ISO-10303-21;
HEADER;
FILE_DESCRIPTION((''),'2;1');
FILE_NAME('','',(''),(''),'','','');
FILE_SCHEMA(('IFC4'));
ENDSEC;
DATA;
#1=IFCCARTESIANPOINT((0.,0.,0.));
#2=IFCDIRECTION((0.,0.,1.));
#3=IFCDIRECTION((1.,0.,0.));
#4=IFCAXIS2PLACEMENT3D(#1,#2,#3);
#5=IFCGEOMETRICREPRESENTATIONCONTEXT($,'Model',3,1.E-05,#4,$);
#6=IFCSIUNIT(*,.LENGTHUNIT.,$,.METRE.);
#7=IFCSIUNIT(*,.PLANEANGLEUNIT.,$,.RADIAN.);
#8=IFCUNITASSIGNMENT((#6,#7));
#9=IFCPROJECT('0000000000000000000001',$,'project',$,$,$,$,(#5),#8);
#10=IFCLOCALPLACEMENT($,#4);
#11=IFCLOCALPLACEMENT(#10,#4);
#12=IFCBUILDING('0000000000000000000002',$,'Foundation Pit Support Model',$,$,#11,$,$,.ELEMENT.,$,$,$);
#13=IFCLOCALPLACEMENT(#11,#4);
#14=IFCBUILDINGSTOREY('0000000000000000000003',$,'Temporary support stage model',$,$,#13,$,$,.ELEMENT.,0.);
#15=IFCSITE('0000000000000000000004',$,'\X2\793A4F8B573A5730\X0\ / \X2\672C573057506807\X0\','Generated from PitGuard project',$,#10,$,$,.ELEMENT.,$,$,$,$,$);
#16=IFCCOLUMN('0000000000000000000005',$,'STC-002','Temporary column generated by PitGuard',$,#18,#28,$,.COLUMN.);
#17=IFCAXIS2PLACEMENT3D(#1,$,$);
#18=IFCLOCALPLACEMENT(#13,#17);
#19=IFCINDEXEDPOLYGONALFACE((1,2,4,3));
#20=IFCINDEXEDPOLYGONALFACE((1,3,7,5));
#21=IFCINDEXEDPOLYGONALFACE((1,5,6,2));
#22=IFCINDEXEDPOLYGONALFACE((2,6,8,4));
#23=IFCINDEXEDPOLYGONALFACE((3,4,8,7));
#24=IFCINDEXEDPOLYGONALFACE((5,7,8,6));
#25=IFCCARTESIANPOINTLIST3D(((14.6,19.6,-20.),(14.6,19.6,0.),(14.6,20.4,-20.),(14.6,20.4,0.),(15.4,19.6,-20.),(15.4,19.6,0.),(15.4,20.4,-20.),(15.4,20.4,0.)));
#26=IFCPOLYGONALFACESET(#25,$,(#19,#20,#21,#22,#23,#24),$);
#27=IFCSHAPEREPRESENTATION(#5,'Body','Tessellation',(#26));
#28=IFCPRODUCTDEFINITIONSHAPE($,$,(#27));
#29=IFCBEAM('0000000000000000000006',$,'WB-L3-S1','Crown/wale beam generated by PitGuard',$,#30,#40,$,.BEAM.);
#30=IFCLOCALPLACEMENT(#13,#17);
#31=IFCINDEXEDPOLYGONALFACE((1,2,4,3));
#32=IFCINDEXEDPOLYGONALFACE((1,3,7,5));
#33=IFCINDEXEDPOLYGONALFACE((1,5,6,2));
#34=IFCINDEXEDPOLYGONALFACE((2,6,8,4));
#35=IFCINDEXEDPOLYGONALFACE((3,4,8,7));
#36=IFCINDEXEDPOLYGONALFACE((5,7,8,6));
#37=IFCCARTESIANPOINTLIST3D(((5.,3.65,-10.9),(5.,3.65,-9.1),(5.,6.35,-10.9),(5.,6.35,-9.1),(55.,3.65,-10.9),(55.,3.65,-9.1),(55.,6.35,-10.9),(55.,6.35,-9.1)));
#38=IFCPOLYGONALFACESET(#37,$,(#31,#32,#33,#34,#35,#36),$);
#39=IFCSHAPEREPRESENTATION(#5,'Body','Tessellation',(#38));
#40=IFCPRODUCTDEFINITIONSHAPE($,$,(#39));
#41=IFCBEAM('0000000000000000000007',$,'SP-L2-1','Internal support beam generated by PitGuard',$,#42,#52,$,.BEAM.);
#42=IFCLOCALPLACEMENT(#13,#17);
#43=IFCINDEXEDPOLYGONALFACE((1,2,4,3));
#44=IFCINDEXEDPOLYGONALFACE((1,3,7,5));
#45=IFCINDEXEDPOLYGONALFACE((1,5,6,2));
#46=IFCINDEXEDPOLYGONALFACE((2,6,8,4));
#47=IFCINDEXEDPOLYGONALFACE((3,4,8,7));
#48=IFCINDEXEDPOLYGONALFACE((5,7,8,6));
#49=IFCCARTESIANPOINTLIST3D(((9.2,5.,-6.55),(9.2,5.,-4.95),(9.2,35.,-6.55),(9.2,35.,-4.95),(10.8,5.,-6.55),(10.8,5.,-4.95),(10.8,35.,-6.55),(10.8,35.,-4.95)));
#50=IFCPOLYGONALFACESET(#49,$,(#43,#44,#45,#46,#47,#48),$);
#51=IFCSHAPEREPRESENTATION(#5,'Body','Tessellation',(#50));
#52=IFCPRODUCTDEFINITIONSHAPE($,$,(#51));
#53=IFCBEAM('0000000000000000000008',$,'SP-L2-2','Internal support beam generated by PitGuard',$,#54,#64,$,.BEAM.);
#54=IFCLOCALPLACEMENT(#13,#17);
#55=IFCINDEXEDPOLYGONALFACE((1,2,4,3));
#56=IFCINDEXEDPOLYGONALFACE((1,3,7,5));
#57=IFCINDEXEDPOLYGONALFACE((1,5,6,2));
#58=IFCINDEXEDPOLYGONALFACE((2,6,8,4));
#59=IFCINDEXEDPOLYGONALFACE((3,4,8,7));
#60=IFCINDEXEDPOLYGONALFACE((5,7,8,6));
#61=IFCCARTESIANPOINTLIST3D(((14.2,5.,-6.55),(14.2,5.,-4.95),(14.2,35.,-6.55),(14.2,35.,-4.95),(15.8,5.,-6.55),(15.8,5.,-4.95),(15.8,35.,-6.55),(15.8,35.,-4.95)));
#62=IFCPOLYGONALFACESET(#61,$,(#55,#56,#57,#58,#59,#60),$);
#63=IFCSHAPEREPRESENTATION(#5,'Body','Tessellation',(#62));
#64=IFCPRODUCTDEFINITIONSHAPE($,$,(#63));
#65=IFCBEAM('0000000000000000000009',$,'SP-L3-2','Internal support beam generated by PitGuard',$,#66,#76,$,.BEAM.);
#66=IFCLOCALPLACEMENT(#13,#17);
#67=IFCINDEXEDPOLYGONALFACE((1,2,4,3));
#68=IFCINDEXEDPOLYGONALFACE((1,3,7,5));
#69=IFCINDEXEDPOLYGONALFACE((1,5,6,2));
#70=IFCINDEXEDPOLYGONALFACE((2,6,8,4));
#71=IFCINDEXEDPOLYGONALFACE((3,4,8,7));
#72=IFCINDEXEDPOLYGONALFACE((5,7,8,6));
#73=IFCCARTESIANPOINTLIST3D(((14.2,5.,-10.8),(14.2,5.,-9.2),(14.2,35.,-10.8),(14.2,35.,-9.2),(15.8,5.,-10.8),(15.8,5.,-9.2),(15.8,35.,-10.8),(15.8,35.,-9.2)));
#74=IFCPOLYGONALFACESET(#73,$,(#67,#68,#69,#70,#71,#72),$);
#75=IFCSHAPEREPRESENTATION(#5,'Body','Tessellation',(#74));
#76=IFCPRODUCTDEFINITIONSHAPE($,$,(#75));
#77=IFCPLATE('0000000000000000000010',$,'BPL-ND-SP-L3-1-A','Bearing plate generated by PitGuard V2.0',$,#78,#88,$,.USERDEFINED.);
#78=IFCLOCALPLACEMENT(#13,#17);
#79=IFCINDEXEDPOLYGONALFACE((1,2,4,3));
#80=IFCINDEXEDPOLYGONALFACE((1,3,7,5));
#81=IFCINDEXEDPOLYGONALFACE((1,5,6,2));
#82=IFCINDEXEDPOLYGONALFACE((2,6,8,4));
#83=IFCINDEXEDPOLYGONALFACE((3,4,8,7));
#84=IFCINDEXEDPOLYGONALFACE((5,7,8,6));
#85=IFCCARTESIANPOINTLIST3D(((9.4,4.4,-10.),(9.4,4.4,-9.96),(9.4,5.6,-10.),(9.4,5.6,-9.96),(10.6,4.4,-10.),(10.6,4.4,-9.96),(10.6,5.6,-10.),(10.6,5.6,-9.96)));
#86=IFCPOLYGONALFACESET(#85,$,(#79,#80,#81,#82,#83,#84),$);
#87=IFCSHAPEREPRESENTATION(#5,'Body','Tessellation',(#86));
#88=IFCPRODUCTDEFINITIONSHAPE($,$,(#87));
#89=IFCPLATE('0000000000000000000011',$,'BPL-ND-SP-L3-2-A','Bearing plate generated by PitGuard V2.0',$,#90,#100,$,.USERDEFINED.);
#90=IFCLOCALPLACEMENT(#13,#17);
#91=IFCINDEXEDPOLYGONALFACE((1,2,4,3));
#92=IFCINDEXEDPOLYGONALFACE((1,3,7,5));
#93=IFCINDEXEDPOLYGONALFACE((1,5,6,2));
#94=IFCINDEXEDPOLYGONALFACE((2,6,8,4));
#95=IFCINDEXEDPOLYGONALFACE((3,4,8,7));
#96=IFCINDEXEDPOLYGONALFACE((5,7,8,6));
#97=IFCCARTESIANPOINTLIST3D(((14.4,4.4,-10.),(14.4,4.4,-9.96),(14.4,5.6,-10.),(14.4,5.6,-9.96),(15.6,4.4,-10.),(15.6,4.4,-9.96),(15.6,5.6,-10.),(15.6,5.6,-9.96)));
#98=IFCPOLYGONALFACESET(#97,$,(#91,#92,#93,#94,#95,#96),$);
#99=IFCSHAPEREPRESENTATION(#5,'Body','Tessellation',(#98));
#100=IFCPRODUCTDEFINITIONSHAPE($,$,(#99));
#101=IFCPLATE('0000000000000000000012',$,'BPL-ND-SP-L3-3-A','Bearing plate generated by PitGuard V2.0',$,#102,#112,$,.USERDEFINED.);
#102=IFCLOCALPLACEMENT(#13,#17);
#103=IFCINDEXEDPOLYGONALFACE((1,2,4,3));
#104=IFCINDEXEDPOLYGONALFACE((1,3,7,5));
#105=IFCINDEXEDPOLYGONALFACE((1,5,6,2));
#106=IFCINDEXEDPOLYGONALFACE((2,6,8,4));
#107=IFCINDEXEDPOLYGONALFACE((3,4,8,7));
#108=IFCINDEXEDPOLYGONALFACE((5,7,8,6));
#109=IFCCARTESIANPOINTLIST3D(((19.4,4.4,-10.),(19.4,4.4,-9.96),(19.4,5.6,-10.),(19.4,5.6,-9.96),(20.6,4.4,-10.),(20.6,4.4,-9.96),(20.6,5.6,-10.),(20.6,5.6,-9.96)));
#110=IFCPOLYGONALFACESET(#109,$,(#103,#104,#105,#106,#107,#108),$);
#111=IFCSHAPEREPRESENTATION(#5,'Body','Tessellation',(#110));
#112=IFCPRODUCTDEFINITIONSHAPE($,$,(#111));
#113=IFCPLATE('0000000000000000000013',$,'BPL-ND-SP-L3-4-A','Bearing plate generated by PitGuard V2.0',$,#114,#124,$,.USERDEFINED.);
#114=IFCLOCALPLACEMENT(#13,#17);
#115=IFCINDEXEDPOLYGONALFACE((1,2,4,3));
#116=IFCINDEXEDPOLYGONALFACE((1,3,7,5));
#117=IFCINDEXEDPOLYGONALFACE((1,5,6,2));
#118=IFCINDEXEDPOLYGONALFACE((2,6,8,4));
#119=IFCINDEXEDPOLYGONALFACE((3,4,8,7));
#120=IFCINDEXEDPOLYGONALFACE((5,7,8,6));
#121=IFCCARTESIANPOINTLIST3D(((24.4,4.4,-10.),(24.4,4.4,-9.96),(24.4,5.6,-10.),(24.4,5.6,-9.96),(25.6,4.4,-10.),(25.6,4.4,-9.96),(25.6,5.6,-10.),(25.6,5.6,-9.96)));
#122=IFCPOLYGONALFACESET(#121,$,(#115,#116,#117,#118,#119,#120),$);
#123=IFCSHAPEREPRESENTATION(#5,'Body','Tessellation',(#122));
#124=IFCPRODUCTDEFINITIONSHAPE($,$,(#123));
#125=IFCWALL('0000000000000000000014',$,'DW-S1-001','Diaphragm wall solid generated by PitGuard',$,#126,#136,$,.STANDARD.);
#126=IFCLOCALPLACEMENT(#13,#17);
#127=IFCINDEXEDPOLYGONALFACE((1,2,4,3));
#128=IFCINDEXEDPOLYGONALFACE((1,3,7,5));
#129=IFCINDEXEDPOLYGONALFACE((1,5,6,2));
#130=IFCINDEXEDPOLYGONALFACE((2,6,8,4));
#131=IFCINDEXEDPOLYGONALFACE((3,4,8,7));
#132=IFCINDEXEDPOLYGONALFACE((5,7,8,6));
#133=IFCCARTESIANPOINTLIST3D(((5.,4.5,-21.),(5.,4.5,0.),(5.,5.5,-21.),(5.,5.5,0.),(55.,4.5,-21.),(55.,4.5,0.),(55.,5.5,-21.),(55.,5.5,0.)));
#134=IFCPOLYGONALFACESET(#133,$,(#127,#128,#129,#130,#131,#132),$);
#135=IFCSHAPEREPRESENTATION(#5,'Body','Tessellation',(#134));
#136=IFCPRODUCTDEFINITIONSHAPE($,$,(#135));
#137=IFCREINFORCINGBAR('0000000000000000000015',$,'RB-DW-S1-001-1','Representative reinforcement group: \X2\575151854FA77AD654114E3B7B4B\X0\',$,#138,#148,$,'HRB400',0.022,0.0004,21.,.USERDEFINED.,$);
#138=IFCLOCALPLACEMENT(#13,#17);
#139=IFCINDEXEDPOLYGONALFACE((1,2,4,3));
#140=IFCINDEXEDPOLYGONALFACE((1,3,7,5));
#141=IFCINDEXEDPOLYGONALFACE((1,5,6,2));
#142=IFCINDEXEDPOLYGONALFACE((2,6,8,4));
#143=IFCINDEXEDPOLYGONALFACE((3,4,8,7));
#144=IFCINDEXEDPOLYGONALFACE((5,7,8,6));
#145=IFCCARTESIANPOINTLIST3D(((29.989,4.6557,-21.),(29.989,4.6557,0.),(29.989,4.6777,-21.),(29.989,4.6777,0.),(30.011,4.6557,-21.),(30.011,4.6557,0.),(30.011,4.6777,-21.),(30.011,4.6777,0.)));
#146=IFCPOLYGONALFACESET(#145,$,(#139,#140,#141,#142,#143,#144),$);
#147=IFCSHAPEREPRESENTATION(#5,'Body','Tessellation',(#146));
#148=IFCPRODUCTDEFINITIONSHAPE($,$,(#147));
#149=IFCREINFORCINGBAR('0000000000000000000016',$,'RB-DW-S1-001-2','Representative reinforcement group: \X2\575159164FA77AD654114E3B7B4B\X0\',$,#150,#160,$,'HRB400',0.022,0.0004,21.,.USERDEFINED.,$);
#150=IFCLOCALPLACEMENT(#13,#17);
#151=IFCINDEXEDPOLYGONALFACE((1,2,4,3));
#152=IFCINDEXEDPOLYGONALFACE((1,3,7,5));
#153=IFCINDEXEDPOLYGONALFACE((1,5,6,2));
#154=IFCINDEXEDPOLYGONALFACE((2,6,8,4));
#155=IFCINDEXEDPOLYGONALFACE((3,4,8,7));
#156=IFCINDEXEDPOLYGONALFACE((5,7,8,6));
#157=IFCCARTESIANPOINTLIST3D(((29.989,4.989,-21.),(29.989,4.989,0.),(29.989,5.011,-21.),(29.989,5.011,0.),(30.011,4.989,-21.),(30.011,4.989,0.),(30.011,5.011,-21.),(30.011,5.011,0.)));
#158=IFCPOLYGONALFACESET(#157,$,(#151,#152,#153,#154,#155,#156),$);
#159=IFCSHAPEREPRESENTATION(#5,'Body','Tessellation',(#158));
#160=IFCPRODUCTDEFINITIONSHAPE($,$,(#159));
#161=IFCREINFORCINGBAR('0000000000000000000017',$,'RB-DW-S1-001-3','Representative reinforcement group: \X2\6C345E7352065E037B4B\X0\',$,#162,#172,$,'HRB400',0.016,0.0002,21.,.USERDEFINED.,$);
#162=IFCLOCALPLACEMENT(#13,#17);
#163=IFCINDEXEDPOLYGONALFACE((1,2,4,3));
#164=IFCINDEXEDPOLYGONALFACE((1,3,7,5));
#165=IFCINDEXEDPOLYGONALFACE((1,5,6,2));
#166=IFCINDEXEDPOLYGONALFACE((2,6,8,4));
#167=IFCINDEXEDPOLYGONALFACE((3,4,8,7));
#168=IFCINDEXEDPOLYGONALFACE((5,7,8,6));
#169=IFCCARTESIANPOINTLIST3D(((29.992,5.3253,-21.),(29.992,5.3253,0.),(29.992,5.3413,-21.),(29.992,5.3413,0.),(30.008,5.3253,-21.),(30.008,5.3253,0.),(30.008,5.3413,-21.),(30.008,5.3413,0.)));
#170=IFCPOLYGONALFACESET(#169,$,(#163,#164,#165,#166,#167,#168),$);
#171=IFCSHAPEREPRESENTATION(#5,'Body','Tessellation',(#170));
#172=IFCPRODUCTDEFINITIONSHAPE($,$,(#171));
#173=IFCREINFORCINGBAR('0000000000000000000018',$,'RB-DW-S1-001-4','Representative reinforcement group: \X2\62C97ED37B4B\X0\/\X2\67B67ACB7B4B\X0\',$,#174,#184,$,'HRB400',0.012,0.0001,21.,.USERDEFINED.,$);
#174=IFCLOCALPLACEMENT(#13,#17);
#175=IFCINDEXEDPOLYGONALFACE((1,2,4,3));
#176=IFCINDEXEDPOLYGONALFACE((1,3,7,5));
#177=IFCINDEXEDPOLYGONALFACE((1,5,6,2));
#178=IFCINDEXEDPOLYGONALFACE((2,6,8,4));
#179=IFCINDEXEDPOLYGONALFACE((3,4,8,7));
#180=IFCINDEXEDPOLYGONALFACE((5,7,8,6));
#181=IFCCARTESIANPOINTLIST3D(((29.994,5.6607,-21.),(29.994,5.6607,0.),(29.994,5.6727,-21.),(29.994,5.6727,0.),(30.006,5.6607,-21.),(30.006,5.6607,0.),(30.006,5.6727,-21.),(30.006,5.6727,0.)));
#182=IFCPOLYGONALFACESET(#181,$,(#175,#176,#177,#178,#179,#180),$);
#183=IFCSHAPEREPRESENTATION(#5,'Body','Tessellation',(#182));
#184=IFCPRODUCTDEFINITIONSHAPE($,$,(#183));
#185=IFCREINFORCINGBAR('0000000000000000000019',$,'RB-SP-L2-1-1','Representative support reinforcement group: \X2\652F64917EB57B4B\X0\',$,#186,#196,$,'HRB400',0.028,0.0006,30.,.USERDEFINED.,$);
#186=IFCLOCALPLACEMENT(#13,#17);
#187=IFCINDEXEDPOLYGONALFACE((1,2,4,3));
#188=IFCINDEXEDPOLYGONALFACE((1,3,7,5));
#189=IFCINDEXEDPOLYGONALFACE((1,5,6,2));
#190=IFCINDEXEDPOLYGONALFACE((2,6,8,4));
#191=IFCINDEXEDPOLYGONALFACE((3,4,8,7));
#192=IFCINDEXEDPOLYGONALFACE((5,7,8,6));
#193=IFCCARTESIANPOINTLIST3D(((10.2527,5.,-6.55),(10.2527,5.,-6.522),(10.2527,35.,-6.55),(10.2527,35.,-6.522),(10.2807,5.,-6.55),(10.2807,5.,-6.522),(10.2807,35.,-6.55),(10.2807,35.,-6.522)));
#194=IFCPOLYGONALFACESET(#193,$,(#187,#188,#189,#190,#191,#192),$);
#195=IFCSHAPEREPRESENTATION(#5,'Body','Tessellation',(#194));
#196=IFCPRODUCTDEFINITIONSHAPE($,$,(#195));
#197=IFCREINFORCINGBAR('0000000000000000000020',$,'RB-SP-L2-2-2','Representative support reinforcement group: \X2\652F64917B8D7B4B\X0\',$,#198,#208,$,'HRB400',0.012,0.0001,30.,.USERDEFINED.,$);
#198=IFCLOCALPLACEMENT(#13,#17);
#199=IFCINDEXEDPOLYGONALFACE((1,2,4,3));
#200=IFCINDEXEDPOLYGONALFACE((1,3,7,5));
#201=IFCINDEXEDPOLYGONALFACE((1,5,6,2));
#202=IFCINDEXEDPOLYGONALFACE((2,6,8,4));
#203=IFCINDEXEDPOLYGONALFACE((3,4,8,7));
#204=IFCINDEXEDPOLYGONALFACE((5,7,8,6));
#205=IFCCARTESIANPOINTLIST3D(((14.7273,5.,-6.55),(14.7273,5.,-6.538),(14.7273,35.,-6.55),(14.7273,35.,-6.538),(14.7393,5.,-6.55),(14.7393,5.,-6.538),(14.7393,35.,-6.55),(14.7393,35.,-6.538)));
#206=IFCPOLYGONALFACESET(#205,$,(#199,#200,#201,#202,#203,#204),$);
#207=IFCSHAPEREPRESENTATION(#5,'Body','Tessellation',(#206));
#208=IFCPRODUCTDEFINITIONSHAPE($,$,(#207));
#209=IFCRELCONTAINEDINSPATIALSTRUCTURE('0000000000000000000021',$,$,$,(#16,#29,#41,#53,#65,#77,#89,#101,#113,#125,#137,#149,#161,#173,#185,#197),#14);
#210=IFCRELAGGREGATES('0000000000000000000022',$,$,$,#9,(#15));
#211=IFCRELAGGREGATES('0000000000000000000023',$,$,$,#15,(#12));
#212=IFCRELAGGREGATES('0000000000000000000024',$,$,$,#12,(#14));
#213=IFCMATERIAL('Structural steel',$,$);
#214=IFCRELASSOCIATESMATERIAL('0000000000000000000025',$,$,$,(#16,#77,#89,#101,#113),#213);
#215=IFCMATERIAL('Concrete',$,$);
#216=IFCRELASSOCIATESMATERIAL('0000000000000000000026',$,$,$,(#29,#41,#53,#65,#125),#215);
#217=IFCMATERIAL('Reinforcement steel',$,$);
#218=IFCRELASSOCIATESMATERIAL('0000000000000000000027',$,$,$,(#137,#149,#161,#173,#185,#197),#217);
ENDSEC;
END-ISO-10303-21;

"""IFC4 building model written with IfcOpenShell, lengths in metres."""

from ifc_helpers import new_model, si_unit, frame, origin_with_axes, origin_2d, place, context, project, spatial, rectangle, extrude, material, element, save


model = new_model("IFC4")

# Units and contexts
model_context = context("Model", 3, precision=1e-05, world=origin_with_axes())
ifc_project = project(units=[si_unit("LENGTHUNIT", "METRE"), si_unit("PLANEANGLEUNIT", "RADIAN")], contexts=[model_context])

# Site, building, storey
site_placement = place(None, origin_with_axes())
site = spatial("IfcSite", under=ifc_project, at=site_placement, Name="示例场地 / 本地坐标", Description="Generated from PitGuard project", CompositionType="ELEMENT")
building_placement = place(site_placement, origin_with_axes())
building = spatial("IfcBuilding", under=site, at=building_placement, Name="Foundation Pit Support Model", CompositionType="ELEMENT")
storey_placement = place(building_placement, origin_with_axes())
storey = spatial("IfcBuildingStorey", under=building, at=storey_placement, Name="Temporary support stage model", CompositionType="ELEMENT", Elevation=0.0)

# Column
ifc_material_1 = material(Name="Structural steel")
column_placement = place(storey_placement, frame((15.0, 20.0, -20.0), z_axis=(0.0, 0.0, 1.0), x_axis=(1.0, 0.0, 0.0)))
element("IfcColumn", 1, at=column_placement, inside=storey, material=ifc_material_1, Name="STC-002", Description="Temporary column generated by PitGuard", PredefinedType="COLUMN", context=model_context, shape_type="SweptSolid", body=[
    extrude(rectangle(XDim=0.8, YDim=0.8, at=origin_2d()), origin_with_axes(), (0.0, 0.0, 1.0), 20.0),
])

# Beams
ifc_material_2 = material(Name="Concrete")
beam_placement = place(storey_placement, frame((30.0, 5.0, -10.9), z_axis=(0.0, 0.0, 1.0), x_axis=(1.0, 0.0, 0.0)))
element("IfcBeam", 2, at=beam_placement, inside=storey, material=ifc_material_2, Name="WB-L3-S1", Description="Crown/wale beam generated by PitGuard", PredefinedType="BEAM", context=model_context, shape_type="SweptSolid", body=[
    extrude(rectangle(XDim=50.0, YDim=2.7, at=origin_2d()), origin_with_axes(), (0.0, 0.0, 1.0), 1.8),
])
for number, where, z_axis, x_axis, name in (
    (3, (10.0, 20.0, -6.55), (0.0, 0.0, 1.0), (0.0, 1.0, 0.0), "SP-L2-1"),
    (4, (15.0, 20.0, -6.55), (0.0, 0.0, 1.0), (0.0, 1.0, 0.0), "SP-L2-2"),
    (5, (15.0, 20.0, -10.8), (0.0, 0.0, 1.0), (0.0, 1.0, 0.0), "SP-L3-2"),
):
    element("IfcBeam", number, at=place(storey_placement, frame(where, z_axis=z_axis, x_axis=x_axis)), inside=storey, material=ifc_material_2, Name=name, Description="Internal support beam generated by PitGuard", PredefinedType="BEAM", context=model_context, shape_type="SweptSolid", body=[
        extrude(rectangle(XDim=30.0, YDim=1.6, at=origin_2d()), origin_with_axes(), (0.0, 0.0, 1.0), 1.6),
    ])

# Plates
for number, where, z_axis, x_axis, name in (
    (6, (10.0, 5.0, -10.0), (0.0, 0.0, 1.0), (1.0, 0.0, 0.0), "BPL-ND-SP-L3-1-A"),
    (7, (15.0, 5.0, -10.0), (0.0, 0.0, 1.0), (1.0, 0.0, 0.0), "BPL-ND-SP-L3-2-A"),
    (8, (20.0, 5.0, -10.0), (0.0, 0.0, 1.0), (1.0, 0.0, 0.0), "BPL-ND-SP-L3-3-A"),
    (9, (25.0, 5.0, -10.0), (0.0, 0.0, 1.0), (1.0, 0.0, 0.0), "BPL-ND-SP-L3-4-A"),
):
    element("IfcPlate", number, at=place(storey_placement, frame(where, z_axis=z_axis, x_axis=x_axis)), inside=storey, material=ifc_material_1, Name=name, Description="Bearing plate generated by PitGuard V2.0", PredefinedType="USERDEFINED", context=model_context, shape_type="SweptSolid", body=[
        extrude(rectangle(XDim=1.2, YDim=1.2, at=origin_2d()), origin_with_axes(), (0.0, 0.0, 1.0), 0.04),
    ])

# Wall
wall_placement = place(storey_placement, frame((30.0, 5.0, -21.0), z_axis=(0.0, 0.0, 1.0), x_axis=(1.0, 0.0, 0.0)))
element("IfcWall", 10, at=wall_placement, inside=storey, material=ifc_material_2, Name="DW-S1-001", Description="Diaphragm wall solid generated by PitGuard", PredefinedType="STANDARD", context=model_context, shape_type="SweptSolid", body=[
    extrude(rectangle(XDim=50.0, YDim=1.0, at=origin_2d()), origin_with_axes(), (0.0, 0.0, 1.0), 21.0),
])

# Reinforcing bars
ifc_material_3 = material(Name="Reinforcement steel")
for number, where, z_axis, x_axis, name, description in (
    (11, (30.0, 4.6667, -21.0), (0.0, 0.0, 1.0), (1.0, 0.0, 0.0), "RB-DW-S1-001-1", "Representative reinforcement group: 坑内侧竖向主筋"),
    (12, (30.0, 5.0, -21.0), (0.0, 0.0, 1.0), (1.0, 0.0, 0.0), "RB-DW-S1-001-2", "Representative reinforcement group: 坑外侧竖向主筋"),
):
    element("IfcReinforcingBar", number, at=place(storey_placement, frame(where, z_axis=z_axis, x_axis=x_axis)), inside=storey, material=ifc_material_3, Name=name, Description=description, SteelGrade="HRB400", BarLength=21.0, CrossSectionArea=0.0004, NominalDiameter=0.022, PredefinedType="USERDEFINED", context=model_context, shape_type="SweptSolid", body=[
        extrude(rectangle(XDim=0.022, YDim=0.022, at=origin_2d()), origin_with_axes(), (0.0, 0.0, 1.0), 21.0),
    ])
reinforcing_bar_1_placement = place(storey_placement, frame((30.0, 5.3333, -21.0), z_axis=(0.0, 0.0, 1.0), x_axis=(1.0, 0.0, 0.0)))
element("IfcReinforcingBar", 13, at=reinforcing_bar_1_placement, inside=storey, material=ifc_material_3, Name="RB-DW-S1-001-3", Description="Representative reinforcement group: 水平分布筋", SteelGrade="HRB400", BarLength=21.0, CrossSectionArea=0.0002, NominalDiameter=0.016, PredefinedType="USERDEFINED", context=model_context, shape_type="SweptSolid", body=[
    extrude(rectangle(XDim=0.016, YDim=0.016, at=origin_2d()), origin_with_axes(), (0.0, 0.0, 1.0), 21.0),
])
reinforcing_bar_2_placement = place(storey_placement, frame((30.0, 5.6667, -21.0), z_axis=(0.0, 0.0, 1.0), x_axis=(1.0, 0.0, 0.0)))
element("IfcReinforcingBar", 14, at=reinforcing_bar_2_placement, inside=storey, material=ifc_material_3, Name="RB-DW-S1-001-4", Description="Representative reinforcement group: 拉结筋/架立筋", SteelGrade="HRB400", BarLength=21.0, CrossSectionArea=0.0001, NominalDiameter=0.012, PredefinedType="USERDEFINED", context=model_context, shape_type="SweptSolid", body=[
    extrude(rectangle(XDim=0.012, YDim=0.012, at=origin_2d()), origin_with_axes(), (0.0, 0.0, 1.0), 21.0),
])
reinforcing_bar_3_placement = place(storey_placement, frame((10.2667, 20.0, -6.55), z_axis=(0.0, 0.0, 1.0), x_axis=(0.0, 1.0, 0.0)))
element("IfcReinforcingBar", 15, at=reinforcing_bar_3_placement, inside=storey, material=ifc_material_3, Name="RB-SP-L2-1-1", Description="Representative support reinforcement group: 支撑纵筋", SteelGrade="HRB400", BarLength=30.0, CrossSectionArea=0.0006, NominalDiameter=0.028, PredefinedType="USERDEFINED", context=model_context, shape_type="SweptSolid", body=[
    extrude(rectangle(XDim=30.0, YDim=0.028, at=origin_2d()), origin_with_axes(), (0.0, 0.0, 1.0), 0.028),
])
reinforcing_bar_4_placement = place(storey_placement, frame((14.7333, 20.0, -6.55), z_axis=(0.0, 0.0, 1.0), x_axis=(0.0, 1.0, 0.0)))
element("IfcReinforcingBar", 16, at=reinforcing_bar_4_placement, inside=storey, material=ifc_material_3, Name="RB-SP-L2-2-2", Description="Representative support reinforcement group: 支撑箍筋", SteelGrade="HRB400", BarLength=30.0, CrossSectionArea=0.0001, NominalDiameter=0.012, PredefinedType="USERDEFINED", context=model_context, shape_type="SweptSolid", body=[
    extrude(rectangle(XDim=30.0, YDim=0.012, at=origin_2d()), origin_with_axes(), (0.0, 0.0, 1.0), 0.012),
])

save(model, "model.ifc")
